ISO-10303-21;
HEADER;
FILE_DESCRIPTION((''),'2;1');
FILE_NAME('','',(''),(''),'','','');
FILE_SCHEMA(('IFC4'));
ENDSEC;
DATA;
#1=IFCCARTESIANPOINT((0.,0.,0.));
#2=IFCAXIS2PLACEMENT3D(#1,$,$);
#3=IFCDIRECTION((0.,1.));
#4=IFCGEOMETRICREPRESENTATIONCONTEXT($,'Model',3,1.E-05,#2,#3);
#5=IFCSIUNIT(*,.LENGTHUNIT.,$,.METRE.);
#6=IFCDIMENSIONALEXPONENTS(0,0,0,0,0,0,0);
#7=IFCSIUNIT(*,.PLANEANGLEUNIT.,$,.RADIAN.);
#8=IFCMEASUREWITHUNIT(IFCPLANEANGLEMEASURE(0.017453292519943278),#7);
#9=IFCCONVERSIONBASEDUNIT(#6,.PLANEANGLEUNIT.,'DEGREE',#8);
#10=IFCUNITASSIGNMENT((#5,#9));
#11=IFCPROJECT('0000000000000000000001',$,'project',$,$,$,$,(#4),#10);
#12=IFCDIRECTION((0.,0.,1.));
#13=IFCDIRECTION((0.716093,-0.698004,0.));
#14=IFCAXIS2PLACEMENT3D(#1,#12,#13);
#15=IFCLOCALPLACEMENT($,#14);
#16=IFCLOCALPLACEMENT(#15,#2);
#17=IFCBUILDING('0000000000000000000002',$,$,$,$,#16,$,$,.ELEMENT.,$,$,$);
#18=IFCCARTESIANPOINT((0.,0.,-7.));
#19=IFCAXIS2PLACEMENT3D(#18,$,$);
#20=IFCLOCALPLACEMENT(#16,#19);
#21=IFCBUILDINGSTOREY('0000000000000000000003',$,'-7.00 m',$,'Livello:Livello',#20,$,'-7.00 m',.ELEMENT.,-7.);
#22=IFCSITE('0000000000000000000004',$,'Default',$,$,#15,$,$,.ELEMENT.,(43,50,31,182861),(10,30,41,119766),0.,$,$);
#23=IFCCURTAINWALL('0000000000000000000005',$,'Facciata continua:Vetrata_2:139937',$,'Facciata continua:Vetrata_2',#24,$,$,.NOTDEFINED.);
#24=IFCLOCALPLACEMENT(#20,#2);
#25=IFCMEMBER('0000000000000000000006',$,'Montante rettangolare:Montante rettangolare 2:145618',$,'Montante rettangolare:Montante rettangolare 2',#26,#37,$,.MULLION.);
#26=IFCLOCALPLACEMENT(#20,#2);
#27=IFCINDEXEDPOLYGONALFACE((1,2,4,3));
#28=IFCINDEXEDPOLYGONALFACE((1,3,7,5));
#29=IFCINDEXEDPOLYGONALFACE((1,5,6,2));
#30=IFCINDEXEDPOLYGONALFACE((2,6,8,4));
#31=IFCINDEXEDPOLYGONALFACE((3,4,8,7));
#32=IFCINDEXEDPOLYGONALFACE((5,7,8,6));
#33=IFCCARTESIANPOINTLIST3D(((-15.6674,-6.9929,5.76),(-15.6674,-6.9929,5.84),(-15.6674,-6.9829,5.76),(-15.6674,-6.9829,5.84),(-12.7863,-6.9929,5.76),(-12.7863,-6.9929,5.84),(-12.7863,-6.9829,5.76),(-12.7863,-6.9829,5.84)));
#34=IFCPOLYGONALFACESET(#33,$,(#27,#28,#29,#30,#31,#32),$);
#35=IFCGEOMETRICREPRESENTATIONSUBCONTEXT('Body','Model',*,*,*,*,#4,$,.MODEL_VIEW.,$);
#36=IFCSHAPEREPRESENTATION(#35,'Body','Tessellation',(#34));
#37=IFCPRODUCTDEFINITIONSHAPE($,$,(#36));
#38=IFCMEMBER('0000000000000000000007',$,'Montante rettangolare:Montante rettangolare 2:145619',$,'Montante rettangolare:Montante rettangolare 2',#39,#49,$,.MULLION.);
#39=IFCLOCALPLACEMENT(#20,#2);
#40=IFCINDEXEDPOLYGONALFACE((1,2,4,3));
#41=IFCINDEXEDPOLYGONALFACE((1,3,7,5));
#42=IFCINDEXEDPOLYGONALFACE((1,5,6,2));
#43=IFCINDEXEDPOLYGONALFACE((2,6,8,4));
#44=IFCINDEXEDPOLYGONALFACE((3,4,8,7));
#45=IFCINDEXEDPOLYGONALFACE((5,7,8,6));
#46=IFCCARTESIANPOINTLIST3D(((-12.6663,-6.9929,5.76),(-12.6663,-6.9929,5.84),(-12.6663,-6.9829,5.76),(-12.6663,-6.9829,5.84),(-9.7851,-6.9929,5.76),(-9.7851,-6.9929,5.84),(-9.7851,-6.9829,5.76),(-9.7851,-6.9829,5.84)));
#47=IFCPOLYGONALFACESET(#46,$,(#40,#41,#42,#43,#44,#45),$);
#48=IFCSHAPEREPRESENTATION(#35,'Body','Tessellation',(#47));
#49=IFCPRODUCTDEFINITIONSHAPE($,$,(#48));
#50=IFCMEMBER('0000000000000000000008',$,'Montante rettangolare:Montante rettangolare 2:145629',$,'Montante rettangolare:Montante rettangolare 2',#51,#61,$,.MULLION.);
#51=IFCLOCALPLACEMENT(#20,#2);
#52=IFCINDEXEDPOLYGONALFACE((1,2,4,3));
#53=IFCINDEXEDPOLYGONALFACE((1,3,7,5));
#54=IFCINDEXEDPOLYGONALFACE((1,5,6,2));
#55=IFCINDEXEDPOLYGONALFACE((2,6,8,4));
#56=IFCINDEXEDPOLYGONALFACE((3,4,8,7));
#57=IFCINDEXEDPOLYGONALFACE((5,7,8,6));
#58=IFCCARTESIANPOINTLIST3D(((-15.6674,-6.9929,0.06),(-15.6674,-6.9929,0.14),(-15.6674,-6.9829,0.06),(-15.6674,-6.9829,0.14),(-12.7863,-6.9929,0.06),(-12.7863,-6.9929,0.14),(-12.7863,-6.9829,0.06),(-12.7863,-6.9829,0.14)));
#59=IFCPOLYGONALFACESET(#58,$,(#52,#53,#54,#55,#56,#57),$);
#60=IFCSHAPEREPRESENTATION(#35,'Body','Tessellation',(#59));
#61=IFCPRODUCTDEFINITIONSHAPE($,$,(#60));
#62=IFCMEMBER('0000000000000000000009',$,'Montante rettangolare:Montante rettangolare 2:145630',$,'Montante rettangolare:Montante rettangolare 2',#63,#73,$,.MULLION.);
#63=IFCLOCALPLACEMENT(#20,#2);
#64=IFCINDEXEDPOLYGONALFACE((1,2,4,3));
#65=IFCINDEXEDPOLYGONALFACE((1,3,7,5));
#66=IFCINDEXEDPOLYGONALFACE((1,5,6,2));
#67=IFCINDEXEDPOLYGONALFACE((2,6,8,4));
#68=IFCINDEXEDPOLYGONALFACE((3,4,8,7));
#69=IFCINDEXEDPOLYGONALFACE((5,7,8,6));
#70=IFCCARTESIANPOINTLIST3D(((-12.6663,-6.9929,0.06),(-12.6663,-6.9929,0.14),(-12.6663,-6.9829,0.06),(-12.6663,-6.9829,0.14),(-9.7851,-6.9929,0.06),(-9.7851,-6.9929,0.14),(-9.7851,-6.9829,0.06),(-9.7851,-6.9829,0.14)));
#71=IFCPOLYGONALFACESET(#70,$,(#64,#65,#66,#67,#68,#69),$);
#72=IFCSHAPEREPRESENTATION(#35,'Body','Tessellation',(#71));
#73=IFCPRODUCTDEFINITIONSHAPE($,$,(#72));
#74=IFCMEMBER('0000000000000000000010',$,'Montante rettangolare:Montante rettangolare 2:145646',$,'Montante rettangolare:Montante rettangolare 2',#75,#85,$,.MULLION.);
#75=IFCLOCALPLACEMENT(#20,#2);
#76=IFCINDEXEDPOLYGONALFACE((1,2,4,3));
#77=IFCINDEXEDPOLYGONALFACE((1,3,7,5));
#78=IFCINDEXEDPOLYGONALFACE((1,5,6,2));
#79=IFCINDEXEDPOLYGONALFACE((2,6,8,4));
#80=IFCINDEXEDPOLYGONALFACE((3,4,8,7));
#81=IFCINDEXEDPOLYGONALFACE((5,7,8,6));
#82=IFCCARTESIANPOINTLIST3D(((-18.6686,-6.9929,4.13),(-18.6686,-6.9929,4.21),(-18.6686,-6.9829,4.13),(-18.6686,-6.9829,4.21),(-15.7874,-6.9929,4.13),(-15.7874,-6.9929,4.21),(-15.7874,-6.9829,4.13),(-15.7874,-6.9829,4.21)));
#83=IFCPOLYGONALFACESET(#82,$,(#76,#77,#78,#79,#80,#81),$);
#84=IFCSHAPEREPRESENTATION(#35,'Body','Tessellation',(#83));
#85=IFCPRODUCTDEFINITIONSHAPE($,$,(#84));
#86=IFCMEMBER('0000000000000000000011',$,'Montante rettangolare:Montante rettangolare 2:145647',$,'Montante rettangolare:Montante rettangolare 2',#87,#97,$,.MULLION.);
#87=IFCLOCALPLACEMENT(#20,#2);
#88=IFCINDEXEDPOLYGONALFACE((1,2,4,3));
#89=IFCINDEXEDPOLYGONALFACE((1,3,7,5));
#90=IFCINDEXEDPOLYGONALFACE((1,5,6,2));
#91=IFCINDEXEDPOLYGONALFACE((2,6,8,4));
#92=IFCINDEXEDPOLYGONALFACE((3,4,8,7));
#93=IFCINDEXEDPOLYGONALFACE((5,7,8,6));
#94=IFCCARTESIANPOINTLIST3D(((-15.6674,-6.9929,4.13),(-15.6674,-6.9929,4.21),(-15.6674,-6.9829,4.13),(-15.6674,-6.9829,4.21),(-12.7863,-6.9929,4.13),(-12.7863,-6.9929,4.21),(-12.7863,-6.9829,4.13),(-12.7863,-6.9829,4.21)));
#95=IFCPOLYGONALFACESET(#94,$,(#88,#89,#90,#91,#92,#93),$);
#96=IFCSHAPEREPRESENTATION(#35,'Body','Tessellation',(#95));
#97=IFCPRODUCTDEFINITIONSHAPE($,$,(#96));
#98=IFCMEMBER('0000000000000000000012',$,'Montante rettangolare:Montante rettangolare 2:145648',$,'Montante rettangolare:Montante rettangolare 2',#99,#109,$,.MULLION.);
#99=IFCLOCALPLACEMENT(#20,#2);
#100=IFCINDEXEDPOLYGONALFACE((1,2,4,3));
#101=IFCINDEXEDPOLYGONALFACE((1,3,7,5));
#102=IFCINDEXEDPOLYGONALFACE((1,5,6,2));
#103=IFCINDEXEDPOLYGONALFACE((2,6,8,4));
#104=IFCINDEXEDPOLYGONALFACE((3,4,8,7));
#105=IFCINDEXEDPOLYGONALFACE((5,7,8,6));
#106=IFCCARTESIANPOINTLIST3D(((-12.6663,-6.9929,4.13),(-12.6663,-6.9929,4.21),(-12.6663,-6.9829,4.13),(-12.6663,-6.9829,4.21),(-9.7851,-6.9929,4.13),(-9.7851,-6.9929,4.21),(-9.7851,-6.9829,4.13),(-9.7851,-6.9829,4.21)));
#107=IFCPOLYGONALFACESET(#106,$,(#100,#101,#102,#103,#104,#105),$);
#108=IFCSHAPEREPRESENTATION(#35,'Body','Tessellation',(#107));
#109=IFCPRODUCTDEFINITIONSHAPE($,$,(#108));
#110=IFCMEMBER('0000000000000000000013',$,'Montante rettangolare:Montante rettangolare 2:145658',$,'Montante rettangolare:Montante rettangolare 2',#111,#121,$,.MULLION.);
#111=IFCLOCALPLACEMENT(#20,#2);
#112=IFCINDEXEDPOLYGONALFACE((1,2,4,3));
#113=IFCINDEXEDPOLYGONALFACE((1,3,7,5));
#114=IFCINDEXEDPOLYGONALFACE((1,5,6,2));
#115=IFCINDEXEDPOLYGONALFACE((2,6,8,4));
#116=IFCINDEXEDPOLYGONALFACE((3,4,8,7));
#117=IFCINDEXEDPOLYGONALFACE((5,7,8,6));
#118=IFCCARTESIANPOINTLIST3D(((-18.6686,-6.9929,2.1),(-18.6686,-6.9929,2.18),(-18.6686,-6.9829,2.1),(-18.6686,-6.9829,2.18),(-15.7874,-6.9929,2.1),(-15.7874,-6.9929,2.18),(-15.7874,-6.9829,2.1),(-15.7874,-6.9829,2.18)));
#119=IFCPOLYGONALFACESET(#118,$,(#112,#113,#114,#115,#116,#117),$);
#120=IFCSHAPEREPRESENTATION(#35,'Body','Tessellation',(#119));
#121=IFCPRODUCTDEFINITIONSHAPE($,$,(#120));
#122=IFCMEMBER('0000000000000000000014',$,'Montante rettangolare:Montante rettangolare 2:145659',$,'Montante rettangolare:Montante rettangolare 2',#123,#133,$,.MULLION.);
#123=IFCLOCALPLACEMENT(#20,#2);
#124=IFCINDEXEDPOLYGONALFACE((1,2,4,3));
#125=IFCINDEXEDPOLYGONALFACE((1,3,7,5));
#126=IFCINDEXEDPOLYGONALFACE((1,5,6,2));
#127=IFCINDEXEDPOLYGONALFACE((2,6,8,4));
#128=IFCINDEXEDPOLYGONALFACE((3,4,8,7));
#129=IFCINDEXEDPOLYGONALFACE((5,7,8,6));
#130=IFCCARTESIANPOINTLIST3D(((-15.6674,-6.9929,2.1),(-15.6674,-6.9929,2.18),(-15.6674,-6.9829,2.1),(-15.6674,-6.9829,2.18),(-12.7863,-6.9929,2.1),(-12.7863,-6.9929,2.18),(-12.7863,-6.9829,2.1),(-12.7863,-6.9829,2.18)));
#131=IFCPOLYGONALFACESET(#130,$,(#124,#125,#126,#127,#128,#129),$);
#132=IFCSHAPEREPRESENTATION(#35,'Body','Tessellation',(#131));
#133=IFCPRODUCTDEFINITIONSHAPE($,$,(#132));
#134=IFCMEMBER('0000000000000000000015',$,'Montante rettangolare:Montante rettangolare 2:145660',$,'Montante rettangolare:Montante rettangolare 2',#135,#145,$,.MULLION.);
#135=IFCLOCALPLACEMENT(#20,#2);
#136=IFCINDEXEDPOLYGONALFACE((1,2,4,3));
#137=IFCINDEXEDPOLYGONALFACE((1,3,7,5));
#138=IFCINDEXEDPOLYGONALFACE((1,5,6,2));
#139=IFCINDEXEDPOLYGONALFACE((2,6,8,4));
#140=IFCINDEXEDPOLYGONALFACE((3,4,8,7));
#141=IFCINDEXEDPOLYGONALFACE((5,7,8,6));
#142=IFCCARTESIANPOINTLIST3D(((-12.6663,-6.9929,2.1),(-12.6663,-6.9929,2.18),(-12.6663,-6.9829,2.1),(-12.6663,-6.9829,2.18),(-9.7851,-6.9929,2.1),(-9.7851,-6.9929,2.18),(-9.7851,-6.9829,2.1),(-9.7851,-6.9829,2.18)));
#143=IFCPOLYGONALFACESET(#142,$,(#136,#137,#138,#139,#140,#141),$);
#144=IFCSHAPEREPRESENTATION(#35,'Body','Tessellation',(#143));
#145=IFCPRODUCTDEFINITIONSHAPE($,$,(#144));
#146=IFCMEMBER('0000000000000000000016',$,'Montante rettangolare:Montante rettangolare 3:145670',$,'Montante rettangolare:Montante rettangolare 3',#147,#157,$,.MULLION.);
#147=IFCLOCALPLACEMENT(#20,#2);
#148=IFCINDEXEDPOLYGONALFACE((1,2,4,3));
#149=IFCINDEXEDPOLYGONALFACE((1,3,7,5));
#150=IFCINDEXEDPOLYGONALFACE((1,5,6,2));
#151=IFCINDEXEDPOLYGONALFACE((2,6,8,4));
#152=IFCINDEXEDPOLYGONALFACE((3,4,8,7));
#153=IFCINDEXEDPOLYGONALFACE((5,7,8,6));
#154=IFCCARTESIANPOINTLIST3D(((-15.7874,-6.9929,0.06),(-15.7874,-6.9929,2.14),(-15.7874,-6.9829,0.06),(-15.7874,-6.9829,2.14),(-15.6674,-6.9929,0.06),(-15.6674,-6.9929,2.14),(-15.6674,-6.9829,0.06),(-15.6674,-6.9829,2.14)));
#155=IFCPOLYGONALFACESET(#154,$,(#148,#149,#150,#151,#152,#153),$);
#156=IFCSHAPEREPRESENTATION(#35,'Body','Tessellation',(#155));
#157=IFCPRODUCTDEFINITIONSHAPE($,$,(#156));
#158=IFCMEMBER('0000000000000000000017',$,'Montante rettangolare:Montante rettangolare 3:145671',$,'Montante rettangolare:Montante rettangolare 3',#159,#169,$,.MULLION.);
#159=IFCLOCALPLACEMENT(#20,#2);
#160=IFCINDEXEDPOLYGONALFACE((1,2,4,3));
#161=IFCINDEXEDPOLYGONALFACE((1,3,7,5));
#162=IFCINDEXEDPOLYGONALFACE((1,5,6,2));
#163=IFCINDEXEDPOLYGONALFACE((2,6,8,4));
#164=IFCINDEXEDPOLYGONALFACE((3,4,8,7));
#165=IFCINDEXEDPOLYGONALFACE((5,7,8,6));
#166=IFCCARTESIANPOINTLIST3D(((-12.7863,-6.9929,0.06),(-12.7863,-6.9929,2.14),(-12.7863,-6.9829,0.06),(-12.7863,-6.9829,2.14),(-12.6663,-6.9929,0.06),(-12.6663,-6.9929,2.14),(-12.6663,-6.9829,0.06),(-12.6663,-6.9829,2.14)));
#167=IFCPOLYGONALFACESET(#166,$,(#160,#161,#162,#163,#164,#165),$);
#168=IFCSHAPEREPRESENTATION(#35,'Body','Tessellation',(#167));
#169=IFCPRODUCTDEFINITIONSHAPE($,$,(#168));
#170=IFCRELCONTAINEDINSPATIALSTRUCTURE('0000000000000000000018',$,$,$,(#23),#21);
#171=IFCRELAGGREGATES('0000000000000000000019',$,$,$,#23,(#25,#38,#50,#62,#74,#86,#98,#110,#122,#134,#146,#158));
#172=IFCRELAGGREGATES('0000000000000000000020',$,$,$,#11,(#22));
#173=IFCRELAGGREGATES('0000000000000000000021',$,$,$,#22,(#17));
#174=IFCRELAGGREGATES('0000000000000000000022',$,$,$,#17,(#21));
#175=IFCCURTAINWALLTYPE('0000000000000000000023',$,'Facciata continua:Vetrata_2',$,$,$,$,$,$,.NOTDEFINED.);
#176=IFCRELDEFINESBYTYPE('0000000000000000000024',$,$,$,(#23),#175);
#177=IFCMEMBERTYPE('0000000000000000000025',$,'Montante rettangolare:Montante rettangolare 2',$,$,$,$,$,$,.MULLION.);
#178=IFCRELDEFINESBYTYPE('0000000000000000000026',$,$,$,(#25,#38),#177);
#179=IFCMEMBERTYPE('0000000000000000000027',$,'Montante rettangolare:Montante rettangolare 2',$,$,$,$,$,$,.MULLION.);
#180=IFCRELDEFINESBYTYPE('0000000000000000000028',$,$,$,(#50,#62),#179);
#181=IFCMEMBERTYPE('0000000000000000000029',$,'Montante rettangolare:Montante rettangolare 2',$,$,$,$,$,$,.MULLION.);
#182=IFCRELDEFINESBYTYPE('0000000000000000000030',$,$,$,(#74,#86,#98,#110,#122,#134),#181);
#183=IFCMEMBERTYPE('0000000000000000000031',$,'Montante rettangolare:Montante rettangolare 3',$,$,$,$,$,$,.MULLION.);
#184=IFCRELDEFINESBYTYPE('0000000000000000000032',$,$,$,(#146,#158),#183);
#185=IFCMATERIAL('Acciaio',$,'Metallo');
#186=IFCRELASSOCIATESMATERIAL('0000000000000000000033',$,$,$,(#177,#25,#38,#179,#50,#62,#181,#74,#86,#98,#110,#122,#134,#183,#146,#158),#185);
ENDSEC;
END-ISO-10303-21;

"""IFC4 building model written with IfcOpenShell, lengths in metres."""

from ifc_helpers import new_model, entity, si_unit, converted_unit, direction, frame, origin, place, context, subcontext, project, spatial, indexed_curve, outline, extrude, source, transform, mapped, material, type_object, type_shapes, element, aggregate, save


model = new_model("IFC4")

# Units and contexts
model_context = context("Model", 3, precision=1e-05, world=origin(), true_north=direction((0.0, 1.0)))
body_context = subcontext(model_context, "Body", "Model", "MODEL_VIEW")
ifc_project = project(units=[si_unit("LENGTHUNIT", "METRE"), converted_unit("PLANEANGLEUNIT", "DEGREE", entity("IfcPlaneAngleMeasure", 0.017453292519943278), si_unit("PLANEANGLEUNIT", "RADIAN"), dimensions=[0, 0, 0, 0, 0, 0, 0])], contexts=[model_context])

# Site, building, storey
site_placement = place(None, frame((0.0, 0.0, 0.0), z_axis=(0.0, 0.0, 1.0), x_axis=(0.716093, -0.698004, 0.0)))
site = spatial("IfcSite", under=ifc_project, at=site_placement, Name="Default", CompositionType="ELEMENT", RefLatitude=(43, 50, 31, 182861), RefLongitude=(10, 30, 41, 119766), RefElevation=0.0)
building_placement = place(site_placement, origin())
building = spatial("IfcBuilding", under=site, at=building_placement, CompositionType="ELEMENT")
storey_placement = place(building_placement, frame((0.0, 0.0, -7.0)))
storey = spatial("IfcBuildingStorey", under=building, at=storey_placement, Name="-7.00 m", ObjectType="Livello:Livello", LongName="-7.00 m", CompositionType="ELEMENT", Elevation=-7.0)

# Curtain wall, members
curtain_wall_type = type_object("IfcCurtainWallType", Name="Facciata continua:Vetrata_2", PredefinedType="NOTDEFINED")
curtain_wall_placement = place(storey_placement, frame((0.0, 0.0, 7.0)))
curtain_wall = element("IfcCurtainWall", 1, at=curtain_wall_placement, inside=storey, type_object=curtain_wall_type, Name="Facciata continua:Vetrata_2:139937", ObjectType="Facciata continua:Vetrata_2", PredefinedType="NOTDEFINED")
ifc_material_1 = material(Name="Acciaio", Category="Metallo")
member_type_1 = type_object("IfcMemberType", Name="Montante rettangolare:Montante rettangolare 2", PredefinedType="MULLION", material=ifc_material_1)
shared_shape_1 = source(origin(), body_context, "Body", "SweptSolid", [
    extrude(outline(indexed_curve([(-0.04, -0.005), (0.04, -0.005), (0.04, 0.005), (-0.04, 0.005), (-0.04, -0.005)], self_intersect=False)), frame((-0.04, 0.01, -2.8812), z_axis=(0.0, 0.0, 1.0), x_axis=(-1.0, 0.0, 0.0)), (0.0, 0.0, 1.0), 2.8812),
])
type_shapes(member_type_1, [shared_shape_1])
member_1_placement = place(curtain_wall_placement, frame((-12.7863, -6.9779, -1.16), z_axis=(1.0, 0.0, 0.0), x_axis=(0.0, 0.0, 1.0)))
member_1 = element("IfcMember", 2, at=member_1_placement, type_object=member_type_1, material=ifc_material_1, Name="Montante rettangolare:Montante rettangolare 2:145618", ObjectType="Montante rettangolare:Montante rettangolare 2", PredefinedType="MULLION", context=body_context, shape_type="MappedRepresentation", body=[
    mapped(shared_shape_1, transform((0.0, 0.0, 0.0), scale=1.0)),
])
member_2_placement = place(curtain_wall_placement, frame((-9.7851, -6.9779, -1.16), z_axis=(1.0, 0.0, 0.0), x_axis=(0.0, 0.0, 1.0)))
member_2 = element("IfcMember", 3, at=member_2_placement, type_object=member_type_1, material=ifc_material_1, Name="Montante rettangolare:Montante rettangolare 2:145619", ObjectType="Montante rettangolare:Montante rettangolare 2", PredefinedType="MULLION", context=body_context, shape_type="MappedRepresentation", body=[
    mapped(shared_shape_1, transform((0.0, 0.0, 0.0), scale=1.0)),
])
member_type_2 = type_object("IfcMemberType", Name="Montante rettangolare:Montante rettangolare 2", PredefinedType="MULLION", material=ifc_material_1)
shared_shape_2 = source(origin(), body_context, "Body", "SweptSolid", [
    extrude(outline(indexed_curve([(-0.04, -0.005), (0.04, -0.005), (0.04, 0.005), (-0.04, 0.005), (-0.04, -0.005)], self_intersect=False)), frame((-0.04, 0.01, -2.8812), z_axis=(0.0, 0.0, 1.0), x_axis=(-1.0, 0.0, 0.0)), (0.0, 0.0, 1.0), 2.8812),
])
type_shapes(member_type_2, [shared_shape_2])
member_3_placement = place(curtain_wall_placement, frame((-15.6674, -6.9779, -6.94), z_axis=(-1.0, 0.0, 0.0), x_axis=(0.0, 0.0, -1.0)))
member_3 = element("IfcMember", 4, at=member_3_placement, type_object=member_type_2, material=ifc_material_1, Name="Montante rettangolare:Montante rettangolare 2:145629", ObjectType="Montante rettangolare:Montante rettangolare 2", PredefinedType="MULLION", context=body_context, shape_type="MappedRepresentation", body=[
    mapped(shared_shape_2, transform((0.0, 0.0, 0.0), scale=1.0)),
])
member_4_placement = place(curtain_wall_placement, frame((-12.6663, -6.9779, -6.94), z_axis=(-1.0, 0.0, 0.0), x_axis=(0.0, 0.0, -1.0)))
member_4 = element("IfcMember", 5, at=member_4_placement, type_object=member_type_2, material=ifc_material_1, Name="Montante rettangolare:Montante rettangolare 2:145630", ObjectType="Montante rettangolare:Montante rettangolare 2", PredefinedType="MULLION", context=body_context, shape_type="MappedRepresentation", body=[
    mapped(shared_shape_2, transform((0.0, 0.0, 0.0), scale=1.0)),
])
member_type_3 = type_object("IfcMemberType", Name="Montante rettangolare:Montante rettangolare 2", PredefinedType="MULLION", material=ifc_material_1)
shared_shape_3 = source(origin(), body_context, "Body", "SweptSolid", [
    extrude(outline(indexed_curve([(-0.04, -0.005), (0.04, -0.005), (0.04, 0.005), (-0.04, 0.005), (-0.04, -0.005)], self_intersect=False)), frame((0.0, 0.01, -2.8812), z_axis=(0.0, 0.0, 1.0), x_axis=(-1.0, 0.0, 0.0)), (0.0, 0.0, 1.0), 2.8812),
])
type_shapes(member_type_3, [shared_shape_3])
member_5_placement = place(curtain_wall_placement, frame((-15.7874, -6.9779, -2.83), z_axis=(1.0, 0.0, 0.0), x_axis=(0.0, 0.0, 1.0)))
member_5 = element("IfcMember", 6, at=member_5_placement, type_object=member_type_3, material=ifc_material_1, Name="Montante rettangolare:Montante rettangolare 2:145646", ObjectType="Montante rettangolare:Montante rettangolare 2", PredefinedType="MULLION", context=body_context, shape_type="MappedRepresentation", body=[
    mapped(shared_shape_3, transform((0.0, 0.0, 0.0), scale=1.0)),
])
member_6_placement = place(curtain_wall_placement, frame((-12.7863, -6.9779, -2.83), z_axis=(1.0, 0.0, 0.0), x_axis=(0.0, 0.0, 1.0)))
member_6 = element("IfcMember", 7, at=member_6_placement, type_object=member_type_3, material=ifc_material_1, Name="Montante rettangolare:Montante rettangolare 2:145647", ObjectType="Montante rettangolare:Montante rettangolare 2", PredefinedType="MULLION", context=body_context, shape_type="MappedRepresentation", body=[
    mapped(shared_shape_3, transform((0.0, 0.0, 0.0), scale=1.0)),
])
member_7_placement = place(curtain_wall_placement, frame((-9.7851, -6.9779, -2.83), z_axis=(1.0, 0.0, 0.0), x_axis=(0.0, 0.0, 1.0)))
member_7 = element("IfcMember", 8, at=member_7_placement, type_object=member_type_3, material=ifc_material_1, Name="Montante rettangolare:Montante rettangolare 2:145648", ObjectType="Montante rettangolare:Montante rettangolare 2", PredefinedType="MULLION", context=body_context, shape_type="MappedRepresentation", body=[
    mapped(shared_shape_3, transform((0.0, 0.0, 0.0), scale=1.0)),
])
member_8_placement = place(curtain_wall_placement, frame((-15.7874, -6.9779, -4.86), z_axis=(1.0, 0.0, 0.0), x_axis=(0.0, 0.0, 1.0)))
member_8 = element("IfcMember", 9, at=member_8_placement, type_object=member_type_3, material=ifc_material_1, Name="Montante rettangolare:Montante rettangolare 2:145658", ObjectType="Montante rettangolare:Montante rettangolare 2", PredefinedType="MULLION", context=body_context, shape_type="MappedRepresentation", body=[
    mapped(shared_shape_3, transform((0.0, 0.0, 0.0), scale=1.0)),
])
member_9_placement = place(curtain_wall_placement, frame((-12.7863, -6.9779, -4.86), z_axis=(1.0, 0.0, 0.0), x_axis=(0.0, 0.0, 1.0)))
member_9 = element("IfcMember", 10, at=member_9_placement, type_object=member_type_3, material=ifc_material_1, Name="Montante rettangolare:Montante rettangolare 2:145659", ObjectType="Montante rettangolare:Montante rettangolare 2", PredefinedType="MULLION", context=body_context, shape_type="MappedRepresentation", body=[
    mapped(shared_shape_3, transform((0.0, 0.0, 0.0), scale=1.0)),
])
member_10_placement = place(curtain_wall_placement, frame((-9.7851, -6.9779, -4.86), z_axis=(1.0, 0.0, 0.0), x_axis=(0.0, 0.0, 1.0)))
member_10 = element("IfcMember", 11, at=member_10_placement, type_object=member_type_3, material=ifc_material_1, Name="Montante rettangolare:Montante rettangolare 2:145660", ObjectType="Montante rettangolare:Montante rettangolare 2", PredefinedType="MULLION", context=body_context, shape_type="MappedRepresentation", body=[
    mapped(shared_shape_3, transform((0.0, 0.0, 0.0), scale=1.0)),
])
member_type_4 = type_object("IfcMemberType", Name="Montante rettangolare:Montante rettangolare 3", PredefinedType="MULLION", material=ifc_material_1)
shared_shape_4 = source(origin(), body_context, "Body", "SweptSolid", [
    extrude(outline(indexed_curve([(-0.06, -0.005), (0.06, -0.005), (0.06, 0.005), (-0.06, 0.005), (-0.06, -0.005)], self_intersect=False)), frame((0.0, 0.01, -2.08), z_axis=(0.0, 0.0, 1.0), x_axis=(-1.0, 0.0, 0.0)), (0.0, 0.0, 1.0), 2.08),
])
type_shapes(member_type_4, [shared_shape_4])
member_11_placement = place(curtain_wall_placement, frame((-15.7274, -6.9779, -6.94), z_axis=(0.0, 0.0, -1.0), x_axis=(1.0, 0.0, 0.0)))
member_11 = element("IfcMember", 12, at=member_11_placement, type_object=member_type_4, material=ifc_material_1, Name="Montante rettangolare:Montante rettangolare 3:145670", ObjectType="Montante rettangolare:Montante rettangolare 3", PredefinedType="MULLION", context=body_context, shape_type="MappedRepresentation", body=[
    mapped(shared_shape_4, transform((0.0, 0.0, 0.0), scale=1.0)),
])
member_12_placement = place(curtain_wall_placement, frame((-12.7263, -6.9779, -6.94), z_axis=(0.0, 0.0, -1.0), x_axis=(1.0, 0.0, 0.0)))
member_12 = element("IfcMember", 13, at=member_12_placement, type_object=member_type_4, material=ifc_material_1, Name="Montante rettangolare:Montante rettangolare 3:145671", ObjectType="Montante rettangolare:Montante rettangolare 3", PredefinedType="MULLION", context=body_context, shape_type="MappedRepresentation", body=[
    mapped(shared_shape_4, transform((0.0, 0.0, 0.0), scale=1.0)),
])
aggregate(curtain_wall, [member_1, member_2, member_3, member_4, member_5, member_6, member_7, member_8, member_9, member_10, member_11, member_12])

save(model, "model.ifc")
